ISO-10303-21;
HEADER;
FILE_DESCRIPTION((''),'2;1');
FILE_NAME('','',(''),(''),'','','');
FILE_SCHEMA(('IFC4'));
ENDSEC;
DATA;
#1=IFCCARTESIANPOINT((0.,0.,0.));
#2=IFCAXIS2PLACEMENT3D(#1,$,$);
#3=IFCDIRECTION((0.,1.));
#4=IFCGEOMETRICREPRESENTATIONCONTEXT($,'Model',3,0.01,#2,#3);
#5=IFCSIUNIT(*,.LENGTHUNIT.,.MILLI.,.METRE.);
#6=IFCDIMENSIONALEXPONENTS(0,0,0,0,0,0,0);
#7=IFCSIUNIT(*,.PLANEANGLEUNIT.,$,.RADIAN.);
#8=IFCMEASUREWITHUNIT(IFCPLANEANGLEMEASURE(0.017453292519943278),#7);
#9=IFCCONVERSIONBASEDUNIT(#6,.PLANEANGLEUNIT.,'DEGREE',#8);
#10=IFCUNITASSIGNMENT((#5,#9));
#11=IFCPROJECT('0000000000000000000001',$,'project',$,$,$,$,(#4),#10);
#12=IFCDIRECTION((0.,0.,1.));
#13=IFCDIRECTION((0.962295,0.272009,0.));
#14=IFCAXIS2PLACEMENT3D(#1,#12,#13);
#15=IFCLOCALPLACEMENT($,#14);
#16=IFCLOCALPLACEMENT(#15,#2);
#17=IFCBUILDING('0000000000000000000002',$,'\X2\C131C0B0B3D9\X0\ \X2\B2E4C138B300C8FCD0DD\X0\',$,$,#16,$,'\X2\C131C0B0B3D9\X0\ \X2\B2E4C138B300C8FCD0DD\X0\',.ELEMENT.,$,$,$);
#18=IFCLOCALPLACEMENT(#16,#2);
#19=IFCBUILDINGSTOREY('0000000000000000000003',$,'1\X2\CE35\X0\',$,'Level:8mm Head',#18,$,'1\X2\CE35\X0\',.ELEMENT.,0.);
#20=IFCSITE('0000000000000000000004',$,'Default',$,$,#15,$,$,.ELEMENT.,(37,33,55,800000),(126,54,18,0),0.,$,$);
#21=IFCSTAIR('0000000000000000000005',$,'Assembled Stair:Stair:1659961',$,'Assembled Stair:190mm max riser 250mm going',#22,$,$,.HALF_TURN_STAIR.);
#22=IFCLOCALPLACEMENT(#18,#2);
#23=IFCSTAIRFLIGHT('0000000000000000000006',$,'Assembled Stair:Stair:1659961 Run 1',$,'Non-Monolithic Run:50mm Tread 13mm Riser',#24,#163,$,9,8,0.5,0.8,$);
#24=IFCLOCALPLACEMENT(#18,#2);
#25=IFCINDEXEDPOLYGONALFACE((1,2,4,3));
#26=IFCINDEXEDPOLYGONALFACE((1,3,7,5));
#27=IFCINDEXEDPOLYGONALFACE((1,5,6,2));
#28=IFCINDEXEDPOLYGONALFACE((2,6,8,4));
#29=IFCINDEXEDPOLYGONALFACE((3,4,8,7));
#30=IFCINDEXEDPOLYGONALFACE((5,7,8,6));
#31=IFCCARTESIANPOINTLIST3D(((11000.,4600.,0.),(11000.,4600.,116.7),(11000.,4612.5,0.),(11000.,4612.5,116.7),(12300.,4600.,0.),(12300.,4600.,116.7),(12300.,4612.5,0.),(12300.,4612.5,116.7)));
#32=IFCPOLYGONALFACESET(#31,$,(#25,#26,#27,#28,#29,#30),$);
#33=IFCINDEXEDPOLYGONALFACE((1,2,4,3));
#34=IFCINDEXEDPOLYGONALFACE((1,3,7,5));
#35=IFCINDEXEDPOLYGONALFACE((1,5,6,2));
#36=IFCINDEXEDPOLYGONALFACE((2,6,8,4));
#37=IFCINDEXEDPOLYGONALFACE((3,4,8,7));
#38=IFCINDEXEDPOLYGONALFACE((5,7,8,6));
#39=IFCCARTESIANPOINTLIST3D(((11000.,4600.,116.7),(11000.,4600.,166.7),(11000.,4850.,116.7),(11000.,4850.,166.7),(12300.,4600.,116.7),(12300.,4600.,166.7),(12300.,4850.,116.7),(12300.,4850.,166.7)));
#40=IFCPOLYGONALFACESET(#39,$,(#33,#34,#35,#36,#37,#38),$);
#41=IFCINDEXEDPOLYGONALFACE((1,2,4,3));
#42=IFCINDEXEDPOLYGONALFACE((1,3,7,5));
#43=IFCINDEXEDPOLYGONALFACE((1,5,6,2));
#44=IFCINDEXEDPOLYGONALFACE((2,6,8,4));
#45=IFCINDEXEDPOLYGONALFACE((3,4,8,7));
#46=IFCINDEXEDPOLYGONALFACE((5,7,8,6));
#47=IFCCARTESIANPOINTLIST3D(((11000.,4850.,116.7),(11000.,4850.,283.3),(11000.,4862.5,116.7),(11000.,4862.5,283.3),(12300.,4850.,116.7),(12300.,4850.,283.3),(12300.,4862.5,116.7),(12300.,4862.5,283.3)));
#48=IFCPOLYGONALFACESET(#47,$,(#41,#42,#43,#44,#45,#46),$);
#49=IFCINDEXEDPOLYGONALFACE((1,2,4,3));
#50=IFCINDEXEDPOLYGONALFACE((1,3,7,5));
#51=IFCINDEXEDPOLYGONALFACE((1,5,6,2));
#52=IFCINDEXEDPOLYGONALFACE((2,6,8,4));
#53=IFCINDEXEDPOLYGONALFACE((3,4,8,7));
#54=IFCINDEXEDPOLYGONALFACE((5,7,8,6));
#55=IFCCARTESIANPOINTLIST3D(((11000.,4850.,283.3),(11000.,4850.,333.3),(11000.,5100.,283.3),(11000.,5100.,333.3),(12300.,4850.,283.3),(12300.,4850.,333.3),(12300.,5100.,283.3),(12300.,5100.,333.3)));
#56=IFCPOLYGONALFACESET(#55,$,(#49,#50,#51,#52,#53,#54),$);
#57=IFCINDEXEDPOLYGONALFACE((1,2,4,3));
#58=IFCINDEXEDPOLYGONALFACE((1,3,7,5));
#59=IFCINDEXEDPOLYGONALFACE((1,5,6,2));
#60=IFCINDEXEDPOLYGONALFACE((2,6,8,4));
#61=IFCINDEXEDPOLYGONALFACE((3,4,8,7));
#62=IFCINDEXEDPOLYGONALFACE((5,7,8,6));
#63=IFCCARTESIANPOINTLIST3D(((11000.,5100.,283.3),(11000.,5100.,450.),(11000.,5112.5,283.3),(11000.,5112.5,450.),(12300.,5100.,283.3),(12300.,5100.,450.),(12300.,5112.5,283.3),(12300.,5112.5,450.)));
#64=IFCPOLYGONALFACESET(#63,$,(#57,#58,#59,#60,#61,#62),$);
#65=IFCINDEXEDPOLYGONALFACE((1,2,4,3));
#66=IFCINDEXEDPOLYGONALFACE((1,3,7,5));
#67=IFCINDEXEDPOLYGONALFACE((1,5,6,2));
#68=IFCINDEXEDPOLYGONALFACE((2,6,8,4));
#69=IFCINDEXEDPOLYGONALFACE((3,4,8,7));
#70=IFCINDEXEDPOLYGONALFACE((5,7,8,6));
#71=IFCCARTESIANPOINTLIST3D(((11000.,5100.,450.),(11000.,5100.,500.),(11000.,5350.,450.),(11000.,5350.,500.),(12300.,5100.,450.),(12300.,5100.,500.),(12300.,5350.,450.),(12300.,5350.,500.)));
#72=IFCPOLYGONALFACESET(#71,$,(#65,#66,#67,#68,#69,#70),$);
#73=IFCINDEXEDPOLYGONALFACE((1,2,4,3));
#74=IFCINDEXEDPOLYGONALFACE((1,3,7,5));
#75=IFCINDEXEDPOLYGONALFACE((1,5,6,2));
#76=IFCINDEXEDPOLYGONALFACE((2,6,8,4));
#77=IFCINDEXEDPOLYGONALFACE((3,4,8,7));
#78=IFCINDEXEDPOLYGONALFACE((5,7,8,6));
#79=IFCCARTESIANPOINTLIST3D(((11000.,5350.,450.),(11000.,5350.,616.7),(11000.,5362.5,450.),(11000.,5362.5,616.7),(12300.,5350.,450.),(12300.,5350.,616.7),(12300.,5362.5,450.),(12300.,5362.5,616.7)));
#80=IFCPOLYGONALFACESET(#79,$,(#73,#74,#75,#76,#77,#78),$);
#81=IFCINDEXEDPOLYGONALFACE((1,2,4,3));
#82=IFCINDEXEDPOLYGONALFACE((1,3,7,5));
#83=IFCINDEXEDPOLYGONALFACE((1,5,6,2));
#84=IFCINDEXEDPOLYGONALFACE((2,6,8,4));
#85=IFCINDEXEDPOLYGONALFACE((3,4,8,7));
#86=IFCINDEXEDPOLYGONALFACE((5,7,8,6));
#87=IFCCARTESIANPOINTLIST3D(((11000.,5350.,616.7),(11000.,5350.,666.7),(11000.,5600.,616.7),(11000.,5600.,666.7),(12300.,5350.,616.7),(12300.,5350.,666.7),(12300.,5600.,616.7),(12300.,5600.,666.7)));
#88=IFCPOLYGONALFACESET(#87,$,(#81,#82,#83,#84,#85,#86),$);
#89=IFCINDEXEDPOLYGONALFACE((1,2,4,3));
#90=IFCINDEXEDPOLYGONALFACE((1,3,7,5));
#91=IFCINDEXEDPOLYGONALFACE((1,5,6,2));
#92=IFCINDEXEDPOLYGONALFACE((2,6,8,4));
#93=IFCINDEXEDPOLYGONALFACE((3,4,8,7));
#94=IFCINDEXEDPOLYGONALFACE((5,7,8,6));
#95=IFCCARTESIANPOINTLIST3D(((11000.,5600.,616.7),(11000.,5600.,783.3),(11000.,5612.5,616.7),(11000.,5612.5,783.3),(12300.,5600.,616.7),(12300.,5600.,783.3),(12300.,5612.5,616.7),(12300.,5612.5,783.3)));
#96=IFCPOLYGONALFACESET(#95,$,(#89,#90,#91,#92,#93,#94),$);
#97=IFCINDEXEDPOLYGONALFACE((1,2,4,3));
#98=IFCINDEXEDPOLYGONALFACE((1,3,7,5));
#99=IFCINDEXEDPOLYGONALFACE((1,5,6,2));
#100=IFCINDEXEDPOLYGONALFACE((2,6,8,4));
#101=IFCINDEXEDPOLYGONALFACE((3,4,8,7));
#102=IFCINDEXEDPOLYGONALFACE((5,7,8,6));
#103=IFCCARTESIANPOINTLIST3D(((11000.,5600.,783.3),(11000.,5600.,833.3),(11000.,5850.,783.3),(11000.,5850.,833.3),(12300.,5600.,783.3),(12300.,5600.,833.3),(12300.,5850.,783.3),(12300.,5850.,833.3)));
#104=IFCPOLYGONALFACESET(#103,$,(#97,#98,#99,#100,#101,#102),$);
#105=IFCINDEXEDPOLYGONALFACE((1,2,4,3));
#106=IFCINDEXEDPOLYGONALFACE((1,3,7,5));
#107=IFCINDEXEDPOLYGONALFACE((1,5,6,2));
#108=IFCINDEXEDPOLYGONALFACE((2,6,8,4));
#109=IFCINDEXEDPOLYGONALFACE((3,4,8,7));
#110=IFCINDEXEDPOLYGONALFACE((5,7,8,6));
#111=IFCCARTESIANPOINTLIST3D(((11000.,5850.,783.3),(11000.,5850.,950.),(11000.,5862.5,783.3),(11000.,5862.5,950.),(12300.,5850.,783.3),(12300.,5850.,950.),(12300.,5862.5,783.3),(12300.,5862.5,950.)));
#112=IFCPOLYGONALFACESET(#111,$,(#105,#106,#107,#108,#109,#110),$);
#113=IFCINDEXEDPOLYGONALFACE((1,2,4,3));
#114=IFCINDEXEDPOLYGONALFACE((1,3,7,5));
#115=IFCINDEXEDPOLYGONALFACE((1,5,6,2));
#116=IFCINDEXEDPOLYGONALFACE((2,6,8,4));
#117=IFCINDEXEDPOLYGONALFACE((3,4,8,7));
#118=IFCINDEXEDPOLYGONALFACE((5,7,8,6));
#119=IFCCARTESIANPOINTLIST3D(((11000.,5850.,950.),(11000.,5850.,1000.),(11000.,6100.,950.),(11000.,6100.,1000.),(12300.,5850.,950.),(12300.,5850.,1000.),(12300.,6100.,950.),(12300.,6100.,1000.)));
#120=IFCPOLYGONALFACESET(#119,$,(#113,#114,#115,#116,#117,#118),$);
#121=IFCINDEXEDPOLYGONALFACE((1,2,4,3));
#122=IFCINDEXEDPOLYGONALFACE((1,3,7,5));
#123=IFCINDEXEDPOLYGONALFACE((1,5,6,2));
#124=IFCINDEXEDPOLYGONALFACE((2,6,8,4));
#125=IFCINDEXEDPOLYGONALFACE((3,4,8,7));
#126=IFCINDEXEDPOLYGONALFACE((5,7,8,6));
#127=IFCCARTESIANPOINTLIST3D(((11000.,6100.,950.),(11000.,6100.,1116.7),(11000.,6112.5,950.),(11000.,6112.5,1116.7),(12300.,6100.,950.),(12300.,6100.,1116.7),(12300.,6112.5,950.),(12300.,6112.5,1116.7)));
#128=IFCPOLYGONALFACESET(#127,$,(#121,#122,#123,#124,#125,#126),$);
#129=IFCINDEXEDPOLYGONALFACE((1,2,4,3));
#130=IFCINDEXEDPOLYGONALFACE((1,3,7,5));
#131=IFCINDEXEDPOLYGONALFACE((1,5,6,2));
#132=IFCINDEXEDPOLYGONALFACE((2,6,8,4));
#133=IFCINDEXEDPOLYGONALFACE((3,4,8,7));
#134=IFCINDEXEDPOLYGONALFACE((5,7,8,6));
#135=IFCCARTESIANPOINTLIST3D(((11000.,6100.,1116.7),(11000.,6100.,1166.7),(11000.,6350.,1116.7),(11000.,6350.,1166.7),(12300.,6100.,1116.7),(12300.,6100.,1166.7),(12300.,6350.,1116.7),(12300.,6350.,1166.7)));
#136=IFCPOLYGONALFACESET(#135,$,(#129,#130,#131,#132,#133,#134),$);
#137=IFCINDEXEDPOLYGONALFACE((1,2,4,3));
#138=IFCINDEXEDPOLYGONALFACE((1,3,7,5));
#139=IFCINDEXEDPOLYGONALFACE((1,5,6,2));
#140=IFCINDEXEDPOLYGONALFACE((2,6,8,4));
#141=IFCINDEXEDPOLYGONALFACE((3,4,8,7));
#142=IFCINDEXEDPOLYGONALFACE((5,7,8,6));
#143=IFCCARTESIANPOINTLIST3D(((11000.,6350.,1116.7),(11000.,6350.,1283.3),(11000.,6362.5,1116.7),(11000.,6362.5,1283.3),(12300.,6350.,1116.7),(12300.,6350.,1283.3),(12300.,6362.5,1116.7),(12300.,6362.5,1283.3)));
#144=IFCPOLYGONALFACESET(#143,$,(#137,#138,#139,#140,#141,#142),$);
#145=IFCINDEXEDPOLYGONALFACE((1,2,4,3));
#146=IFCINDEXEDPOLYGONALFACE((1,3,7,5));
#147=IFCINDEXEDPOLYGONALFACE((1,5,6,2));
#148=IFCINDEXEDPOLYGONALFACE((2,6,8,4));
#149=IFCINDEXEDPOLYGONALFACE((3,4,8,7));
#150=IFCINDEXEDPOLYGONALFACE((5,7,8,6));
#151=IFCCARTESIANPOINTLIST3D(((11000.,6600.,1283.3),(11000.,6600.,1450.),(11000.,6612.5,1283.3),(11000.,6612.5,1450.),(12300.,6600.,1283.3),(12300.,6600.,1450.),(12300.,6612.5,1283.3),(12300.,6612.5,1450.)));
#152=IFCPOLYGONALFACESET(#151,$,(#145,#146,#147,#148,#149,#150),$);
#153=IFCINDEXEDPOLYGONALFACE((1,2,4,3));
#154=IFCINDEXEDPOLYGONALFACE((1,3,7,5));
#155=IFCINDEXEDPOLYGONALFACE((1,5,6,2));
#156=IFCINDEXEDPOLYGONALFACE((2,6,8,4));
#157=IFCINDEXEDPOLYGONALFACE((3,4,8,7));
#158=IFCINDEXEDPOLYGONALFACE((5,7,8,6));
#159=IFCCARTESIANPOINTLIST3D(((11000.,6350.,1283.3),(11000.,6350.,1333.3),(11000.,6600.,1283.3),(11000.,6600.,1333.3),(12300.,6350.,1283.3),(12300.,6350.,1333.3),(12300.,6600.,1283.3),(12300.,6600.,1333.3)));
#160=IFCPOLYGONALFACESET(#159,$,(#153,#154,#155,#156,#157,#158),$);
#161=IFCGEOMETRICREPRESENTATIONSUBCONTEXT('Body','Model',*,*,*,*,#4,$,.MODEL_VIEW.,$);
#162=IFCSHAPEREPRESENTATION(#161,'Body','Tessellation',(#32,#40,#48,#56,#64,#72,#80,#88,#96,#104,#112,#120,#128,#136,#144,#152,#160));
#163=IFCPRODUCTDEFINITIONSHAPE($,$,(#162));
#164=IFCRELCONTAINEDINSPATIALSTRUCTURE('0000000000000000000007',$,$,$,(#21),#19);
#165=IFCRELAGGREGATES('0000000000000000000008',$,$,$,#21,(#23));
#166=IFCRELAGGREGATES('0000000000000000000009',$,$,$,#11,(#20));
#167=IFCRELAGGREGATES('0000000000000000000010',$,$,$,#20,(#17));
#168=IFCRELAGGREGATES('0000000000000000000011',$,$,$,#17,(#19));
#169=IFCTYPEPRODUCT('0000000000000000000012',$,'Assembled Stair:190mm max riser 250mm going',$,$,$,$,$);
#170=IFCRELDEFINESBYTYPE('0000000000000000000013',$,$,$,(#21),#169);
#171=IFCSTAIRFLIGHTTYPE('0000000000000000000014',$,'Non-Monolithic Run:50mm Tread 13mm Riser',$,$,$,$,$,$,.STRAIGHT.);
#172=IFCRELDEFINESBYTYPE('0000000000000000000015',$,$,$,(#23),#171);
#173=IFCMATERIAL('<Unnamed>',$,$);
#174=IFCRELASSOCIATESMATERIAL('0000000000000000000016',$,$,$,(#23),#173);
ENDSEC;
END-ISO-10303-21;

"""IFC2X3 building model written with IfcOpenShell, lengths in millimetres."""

from ifc_helpers import new_model, entity, si_unit, converted_unit, direction, frame, frame_2d, origin, origin_2d_with_axis, place, context, subcontext, project, spatial, rectangle, extrude, material, type_object, element, aggregate, save


model = new_model("IFC2X3")

# Units and contexts
model_context = context("Model", 3, precision=0.01, world=origin(), true_north=direction((0.0, 1.0)))
body_context = subcontext(model_context, "Body", "Model", "MODEL_VIEW")
ifc_project = project(units=[si_unit("LENGTHUNIT", "METRE", prefix="MILLI"), converted_unit("PLANEANGLEUNIT", "DEGREE", entity("IfcPlaneAngleMeasure", 0.017453292519943278), si_unit("PLANEANGLEUNIT", "RADIAN"), dimensions=[0, 0, 0, 0, 0, 0, 0])], contexts=[model_context])

# Site, building, storey
site_placement = place(None, frame((0.0, 0.0, 0.0), z_axis=(0.0, 0.0, 1.0), x_axis=(0.962295, 0.272009, 0.0)))
site = spatial("IfcSite", under=ifc_project, at=site_placement, Name="Default", CompositionType="ELEMENT", RefLatitude=(37, 33, 55, 800000), RefLongitude=(126, 54, 18, 0), RefElevation=0.0)
building_placement = place(site_placement, origin())
building = spatial("IfcBuilding", under=site, at=building_placement, Name="성산동 다세대주택", LongName="성산동 다세대주택", CompositionType="ELEMENT")
storey_placement = place(building_placement, origin())
storey = spatial("IfcBuildingStorey", under=building, at=storey_placement, Name="1층", ObjectType="Level:8mm Head", LongName="1층", CompositionType="ELEMENT", Elevation=0.0)

# Stair
type_product = type_object("IfcTypeProduct", Name="Assembled Stair:190mm max riser 250mm going")
stair_placement = place(storey_placement, origin())
stair = element("IfcStair", 1, at=stair_placement, inside=storey, type_object=type_product, Name="Assembled Stair:Stair:1659961", ObjectType="Assembled Stair:190mm max riser 250mm going", ShapeType="HALF_TURN_STAIR")
ifc_material_1 = material(Name="<Unnamed>")

# Stair flight
stair_flight_type = type_object("IfcStairFlightType", Name="Non-Monolithic Run:50mm Tread 13mm Riser", PredefinedType="STRAIGHT")
stair_flight_1_placement = place(stair_placement, origin())
stair_flight_1 = element("IfcStairFlight", 2, at=stair_flight_1_placement, type_object=stair_flight_type, material=ifc_material_1, Name="Assembled Stair:Stair:1659961 Run 1", ObjectType="Non-Monolithic Run:50mm Tread 13mm Riser", NumberOfRiser=9, NumberOfTreads=8, RiserHeight=0.5, TreadLength=0.8, context=body_context, shape_type="SweptSolid", body=[
    extrude(rectangle(XDim=1300.0, YDim=12.5, at=frame_2d((0.0, 0.0), x_axis=(1.0, 0.0))), frame((11650.0, 4606.2, 0.0), z_axis=(0.0, 0.0, 1.0), x_axis=(-1.0, 0.0, 0.0)), (0.0, 0.0, 1.0), 116.7),
    extrude(rectangle(XDim=250.0, YDim=1300.0, at=frame_2d((0.0, 0.0), x_axis=(1.0, 0.0))), frame((11650.0, 4725.0, 116.7), z_axis=(0.0, 0.0, 1.0), x_axis=(0.0, -1.0, 0.0)), (0.0, 0.0, 1.0), 50.0),
    extrude(rectangle(XDim=1300.0, YDim=12.5, at=frame_2d((0.0, 0.0), x_axis=(1.0, 0.0))), frame((11650.0, 4856.2, 116.7), z_axis=(0.0, 0.0, 1.0), x_axis=(-1.0, 0.0, 0.0)), (0.0, 0.0, 1.0), 166.7),
    extrude(rectangle(XDim=250.0, YDim=1300.0, at=origin_2d_with_axis()), frame((11650.0, 4975.0, 283.3), z_axis=(0.0, 0.0, 1.0), x_axis=(0.0, -1.0, 0.0)), (0.0, 0.0, 1.0), 50.0),
    extrude(rectangle(XDim=1300.0, YDim=12.5, at=frame_2d((0.0, 0.0), x_axis=(1.0, 0.0))), frame((11650.0, 5106.3, 283.3), z_axis=(0.0, 0.0, 1.0), x_axis=(-1.0, 0.0, 0.0)), (0.0, 0.0, 1.0), 166.7),
    extrude(rectangle(XDim=250.0, YDim=1300.0, at=origin_2d_with_axis()), frame((11650.0, 5225.0, 450.0), z_axis=(0.0, 0.0, 1.0), x_axis=(0.0, -1.0, 0.0)), (0.0, 0.0, 1.0), 50.0),
    extrude(rectangle(XDim=1300.0, YDim=12.5, at=frame_2d((0.0, 0.0), x_axis=(1.0, 0.0))), frame((11650.0, 5356.3, 450.0), z_axis=(0.0, 0.0, 1.0), x_axis=(-1.0, 0.0, 0.0)), (0.0, 0.0, 1.0), 166.7),
    extrude(rectangle(XDim=250.0, YDim=1300.0, at=origin_2d_with_axis()), frame((11650.0, 5475.0, 616.7), z_axis=(0.0, 0.0, 1.0), x_axis=(0.0, -1.0, 0.0)), (0.0, 0.0, 1.0), 50.0),
    extrude(rectangle(XDim=1300.0, YDim=12.5, at=origin_2d_with_axis()), frame((11650.0, 5606.2, 616.7), z_axis=(0.0, 0.0, 1.0), x_axis=(-1.0, 0.0, 0.0)), (0.0, 0.0, 1.0), 166.7),
    extrude(rectangle(XDim=250.0, YDim=1300.0, at=origin_2d_with_axis()), frame((11650.0, 5725.0, 783.3), z_axis=(0.0, 0.0, 1.0), x_axis=(0.0, -1.0, 0.0)), (0.0, 0.0, 1.0), 50.0),
    extrude(rectangle(XDim=1300.0, YDim=12.5, at=origin_2d_with_axis()), frame((11650.0, 5856.2, 783.3), z_axis=(0.0, 0.0, 1.0), x_axis=(-1.0, 0.0, 0.0)), (0.0, 0.0, 1.0), 166.7),
    extrude(rectangle(XDim=250.0, YDim=1300.0, at=origin_2d_with_axis()), frame((11650.0, 5975.0, 950.0), z_axis=(0.0, 0.0, 1.0), x_axis=(0.0, -1.0, 0.0)), (0.0, 0.0, 1.0), 50.0),
    extrude(rectangle(XDim=1300.0, YDim=12.5, at=frame_2d((0.0, 0.0), x_axis=(1.0, 0.0))), frame((11650.0, 6106.2, 950.0), z_axis=(0.0, 0.0, 1.0), x_axis=(-1.0, 0.0, 0.0)), (0.0, 0.0, 1.0), 166.7),
    extrude(rectangle(XDim=250.0, YDim=1300.0, at=origin_2d_with_axis()), frame((11650.0, 6225.0, 1116.7), z_axis=(0.0, 0.0, 1.0), x_axis=(0.0, -1.0, 0.0)), (0.0, 0.0, 1.0), 50.0),
    extrude(rectangle(XDim=1300.0, YDim=12.5, at=frame_2d((0.0, 0.0), x_axis=(1.0, 0.0))), frame((11650.0, 6356.2, 1116.7), z_axis=(0.0, 0.0, 1.0), x_axis=(-1.0, 0.0, 0.0)), (0.0, 0.0, 1.0), 166.7),
    extrude(rectangle(XDim=1300.0, YDim=12.5, at=frame_2d((0.0, 0.0), x_axis=(1.0, 0.0))), frame((11650.0, 6606.2, 1283.3), z_axis=(0.0, 0.0, 1.0), x_axis=(-1.0, 0.0, 0.0)), (0.0, 0.0, 1.0), 166.7),
    extrude(rectangle(XDim=250.0, YDim=1300.0, at=origin_2d_with_axis()), frame((11650.0, 6475.0, 1283.3), z_axis=(0.0, 0.0, 1.0), x_axis=(0.0, -1.0, 0.0)), (0.0, 0.0, 1.0), 50.0),
])
aggregate(stair, [stair_flight_1])

save(model, "model.ifc")
